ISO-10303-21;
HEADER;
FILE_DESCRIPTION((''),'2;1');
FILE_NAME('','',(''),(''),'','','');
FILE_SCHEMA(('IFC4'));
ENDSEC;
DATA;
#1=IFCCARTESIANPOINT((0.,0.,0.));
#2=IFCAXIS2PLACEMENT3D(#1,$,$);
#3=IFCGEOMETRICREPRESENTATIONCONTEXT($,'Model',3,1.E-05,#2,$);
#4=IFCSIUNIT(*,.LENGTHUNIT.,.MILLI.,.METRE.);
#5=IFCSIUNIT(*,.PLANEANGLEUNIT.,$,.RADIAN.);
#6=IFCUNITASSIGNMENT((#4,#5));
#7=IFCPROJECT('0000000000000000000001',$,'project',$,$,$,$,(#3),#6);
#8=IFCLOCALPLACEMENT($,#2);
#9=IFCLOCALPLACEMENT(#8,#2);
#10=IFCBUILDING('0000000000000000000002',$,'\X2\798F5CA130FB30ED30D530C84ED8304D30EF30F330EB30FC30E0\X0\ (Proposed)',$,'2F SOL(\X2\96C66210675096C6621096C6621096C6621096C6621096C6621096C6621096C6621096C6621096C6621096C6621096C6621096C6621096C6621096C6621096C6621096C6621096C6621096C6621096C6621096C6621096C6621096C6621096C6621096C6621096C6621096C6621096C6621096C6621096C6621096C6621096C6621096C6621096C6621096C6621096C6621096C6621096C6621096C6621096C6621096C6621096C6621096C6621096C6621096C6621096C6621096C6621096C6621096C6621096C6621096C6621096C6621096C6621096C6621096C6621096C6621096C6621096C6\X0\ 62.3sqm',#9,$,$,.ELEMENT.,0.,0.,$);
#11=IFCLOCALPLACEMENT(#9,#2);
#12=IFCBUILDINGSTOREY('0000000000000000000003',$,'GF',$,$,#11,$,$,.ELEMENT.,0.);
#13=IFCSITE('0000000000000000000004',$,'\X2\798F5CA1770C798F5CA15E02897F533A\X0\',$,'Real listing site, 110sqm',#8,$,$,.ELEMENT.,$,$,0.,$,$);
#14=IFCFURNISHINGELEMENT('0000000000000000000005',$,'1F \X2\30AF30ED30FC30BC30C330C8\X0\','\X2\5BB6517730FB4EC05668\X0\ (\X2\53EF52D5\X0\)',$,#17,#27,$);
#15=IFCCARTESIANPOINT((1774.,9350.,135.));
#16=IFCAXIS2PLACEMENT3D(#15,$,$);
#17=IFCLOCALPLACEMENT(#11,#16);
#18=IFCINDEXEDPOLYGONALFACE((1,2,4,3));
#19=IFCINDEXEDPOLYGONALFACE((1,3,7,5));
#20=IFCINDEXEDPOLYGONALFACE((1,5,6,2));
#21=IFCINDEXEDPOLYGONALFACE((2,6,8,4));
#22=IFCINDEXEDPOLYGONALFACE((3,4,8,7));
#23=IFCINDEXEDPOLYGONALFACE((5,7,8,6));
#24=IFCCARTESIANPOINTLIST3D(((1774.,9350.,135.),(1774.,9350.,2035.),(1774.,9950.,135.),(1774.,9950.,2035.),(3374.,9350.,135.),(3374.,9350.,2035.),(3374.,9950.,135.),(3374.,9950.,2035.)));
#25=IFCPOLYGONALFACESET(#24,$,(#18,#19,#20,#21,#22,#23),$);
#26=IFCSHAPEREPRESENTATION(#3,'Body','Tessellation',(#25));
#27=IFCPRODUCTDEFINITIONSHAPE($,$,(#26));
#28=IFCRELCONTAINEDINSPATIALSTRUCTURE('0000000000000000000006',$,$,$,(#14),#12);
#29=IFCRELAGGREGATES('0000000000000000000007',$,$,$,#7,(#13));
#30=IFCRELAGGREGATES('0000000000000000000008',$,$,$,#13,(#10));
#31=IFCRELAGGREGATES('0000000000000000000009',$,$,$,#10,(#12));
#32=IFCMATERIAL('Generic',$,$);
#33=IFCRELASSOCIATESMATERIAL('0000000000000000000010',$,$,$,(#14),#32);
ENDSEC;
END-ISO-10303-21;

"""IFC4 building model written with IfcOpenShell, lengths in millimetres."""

from ifc_helpers import new_model, si_unit, frame, frame_2d, origin, place, context, project, spatial, rectangle, extrude, material, element, save


model = new_model("IFC4")

# Units and contexts
model_context = context("Model", 3, precision=1e-05, world=origin())
ifc_project = project(units=[si_unit("LENGTHUNIT", "METRE", prefix="MILLI"), si_unit("PLANEANGLEUNIT", "RADIAN")], contexts=[model_context])

# Site, building, storey
site_placement = place(None, origin())
site = spatial("IfcSite", under=ifc_project, at=site_placement, Name="福岡県福岡市西区", ObjectType="Real listing site, 110sqm", CompositionType="ELEMENT", RefElevation=0.0)
building_placement = place(site_placement, origin())
building = spatial("IfcBuilding", under=site, at=building_placement, Name="福岡・ロフト付きワンルーム (Proposed)", ObjectType="2F SOL(集成材集成集成集成集成集成集成集成集成集成集成集成集成集成集成集成集成集成集成集成集成集成集成集成集成集成集成集成集成集成集成集成集成集成集成集成集成集成集成集成集成集成集成集成集成集成集成集成集成集成集成集成集成集成集成集成集成集 62.3sqm", CompositionType="ELEMENT", ElevationOfRefHeight=0.0, ElevationOfTerrain=0.0)
storey_placement = place(building_placement, origin())
storey = spatial("IfcBuildingStorey", under=building, at=storey_placement, Name="GF", CompositionType="ELEMENT", Elevation=0.0)

# Shared definitions
ifc_material_1 = material(Name="Generic")

# Furnishing element
furnishing_placement = place(storey_placement, frame((1774.0, 9350.0, 135.0)))
element("IfcFurnishingElement", 1, at=furnishing_placement, inside=storey, material=ifc_material_1, Name="1F クローゼット", Description="家具・什器 (可動)", context=model_context, shape_type="SweptSolid", body=[
    extrude(rectangle(XDim=1600.0, YDim=600.0, at=frame_2d((800.0, 300.0))), frame((1774.0, 9350.0, 135.0)), (0.0, 0.0, 1.0), 1900.0),
])

save(model, "model.ifc")
